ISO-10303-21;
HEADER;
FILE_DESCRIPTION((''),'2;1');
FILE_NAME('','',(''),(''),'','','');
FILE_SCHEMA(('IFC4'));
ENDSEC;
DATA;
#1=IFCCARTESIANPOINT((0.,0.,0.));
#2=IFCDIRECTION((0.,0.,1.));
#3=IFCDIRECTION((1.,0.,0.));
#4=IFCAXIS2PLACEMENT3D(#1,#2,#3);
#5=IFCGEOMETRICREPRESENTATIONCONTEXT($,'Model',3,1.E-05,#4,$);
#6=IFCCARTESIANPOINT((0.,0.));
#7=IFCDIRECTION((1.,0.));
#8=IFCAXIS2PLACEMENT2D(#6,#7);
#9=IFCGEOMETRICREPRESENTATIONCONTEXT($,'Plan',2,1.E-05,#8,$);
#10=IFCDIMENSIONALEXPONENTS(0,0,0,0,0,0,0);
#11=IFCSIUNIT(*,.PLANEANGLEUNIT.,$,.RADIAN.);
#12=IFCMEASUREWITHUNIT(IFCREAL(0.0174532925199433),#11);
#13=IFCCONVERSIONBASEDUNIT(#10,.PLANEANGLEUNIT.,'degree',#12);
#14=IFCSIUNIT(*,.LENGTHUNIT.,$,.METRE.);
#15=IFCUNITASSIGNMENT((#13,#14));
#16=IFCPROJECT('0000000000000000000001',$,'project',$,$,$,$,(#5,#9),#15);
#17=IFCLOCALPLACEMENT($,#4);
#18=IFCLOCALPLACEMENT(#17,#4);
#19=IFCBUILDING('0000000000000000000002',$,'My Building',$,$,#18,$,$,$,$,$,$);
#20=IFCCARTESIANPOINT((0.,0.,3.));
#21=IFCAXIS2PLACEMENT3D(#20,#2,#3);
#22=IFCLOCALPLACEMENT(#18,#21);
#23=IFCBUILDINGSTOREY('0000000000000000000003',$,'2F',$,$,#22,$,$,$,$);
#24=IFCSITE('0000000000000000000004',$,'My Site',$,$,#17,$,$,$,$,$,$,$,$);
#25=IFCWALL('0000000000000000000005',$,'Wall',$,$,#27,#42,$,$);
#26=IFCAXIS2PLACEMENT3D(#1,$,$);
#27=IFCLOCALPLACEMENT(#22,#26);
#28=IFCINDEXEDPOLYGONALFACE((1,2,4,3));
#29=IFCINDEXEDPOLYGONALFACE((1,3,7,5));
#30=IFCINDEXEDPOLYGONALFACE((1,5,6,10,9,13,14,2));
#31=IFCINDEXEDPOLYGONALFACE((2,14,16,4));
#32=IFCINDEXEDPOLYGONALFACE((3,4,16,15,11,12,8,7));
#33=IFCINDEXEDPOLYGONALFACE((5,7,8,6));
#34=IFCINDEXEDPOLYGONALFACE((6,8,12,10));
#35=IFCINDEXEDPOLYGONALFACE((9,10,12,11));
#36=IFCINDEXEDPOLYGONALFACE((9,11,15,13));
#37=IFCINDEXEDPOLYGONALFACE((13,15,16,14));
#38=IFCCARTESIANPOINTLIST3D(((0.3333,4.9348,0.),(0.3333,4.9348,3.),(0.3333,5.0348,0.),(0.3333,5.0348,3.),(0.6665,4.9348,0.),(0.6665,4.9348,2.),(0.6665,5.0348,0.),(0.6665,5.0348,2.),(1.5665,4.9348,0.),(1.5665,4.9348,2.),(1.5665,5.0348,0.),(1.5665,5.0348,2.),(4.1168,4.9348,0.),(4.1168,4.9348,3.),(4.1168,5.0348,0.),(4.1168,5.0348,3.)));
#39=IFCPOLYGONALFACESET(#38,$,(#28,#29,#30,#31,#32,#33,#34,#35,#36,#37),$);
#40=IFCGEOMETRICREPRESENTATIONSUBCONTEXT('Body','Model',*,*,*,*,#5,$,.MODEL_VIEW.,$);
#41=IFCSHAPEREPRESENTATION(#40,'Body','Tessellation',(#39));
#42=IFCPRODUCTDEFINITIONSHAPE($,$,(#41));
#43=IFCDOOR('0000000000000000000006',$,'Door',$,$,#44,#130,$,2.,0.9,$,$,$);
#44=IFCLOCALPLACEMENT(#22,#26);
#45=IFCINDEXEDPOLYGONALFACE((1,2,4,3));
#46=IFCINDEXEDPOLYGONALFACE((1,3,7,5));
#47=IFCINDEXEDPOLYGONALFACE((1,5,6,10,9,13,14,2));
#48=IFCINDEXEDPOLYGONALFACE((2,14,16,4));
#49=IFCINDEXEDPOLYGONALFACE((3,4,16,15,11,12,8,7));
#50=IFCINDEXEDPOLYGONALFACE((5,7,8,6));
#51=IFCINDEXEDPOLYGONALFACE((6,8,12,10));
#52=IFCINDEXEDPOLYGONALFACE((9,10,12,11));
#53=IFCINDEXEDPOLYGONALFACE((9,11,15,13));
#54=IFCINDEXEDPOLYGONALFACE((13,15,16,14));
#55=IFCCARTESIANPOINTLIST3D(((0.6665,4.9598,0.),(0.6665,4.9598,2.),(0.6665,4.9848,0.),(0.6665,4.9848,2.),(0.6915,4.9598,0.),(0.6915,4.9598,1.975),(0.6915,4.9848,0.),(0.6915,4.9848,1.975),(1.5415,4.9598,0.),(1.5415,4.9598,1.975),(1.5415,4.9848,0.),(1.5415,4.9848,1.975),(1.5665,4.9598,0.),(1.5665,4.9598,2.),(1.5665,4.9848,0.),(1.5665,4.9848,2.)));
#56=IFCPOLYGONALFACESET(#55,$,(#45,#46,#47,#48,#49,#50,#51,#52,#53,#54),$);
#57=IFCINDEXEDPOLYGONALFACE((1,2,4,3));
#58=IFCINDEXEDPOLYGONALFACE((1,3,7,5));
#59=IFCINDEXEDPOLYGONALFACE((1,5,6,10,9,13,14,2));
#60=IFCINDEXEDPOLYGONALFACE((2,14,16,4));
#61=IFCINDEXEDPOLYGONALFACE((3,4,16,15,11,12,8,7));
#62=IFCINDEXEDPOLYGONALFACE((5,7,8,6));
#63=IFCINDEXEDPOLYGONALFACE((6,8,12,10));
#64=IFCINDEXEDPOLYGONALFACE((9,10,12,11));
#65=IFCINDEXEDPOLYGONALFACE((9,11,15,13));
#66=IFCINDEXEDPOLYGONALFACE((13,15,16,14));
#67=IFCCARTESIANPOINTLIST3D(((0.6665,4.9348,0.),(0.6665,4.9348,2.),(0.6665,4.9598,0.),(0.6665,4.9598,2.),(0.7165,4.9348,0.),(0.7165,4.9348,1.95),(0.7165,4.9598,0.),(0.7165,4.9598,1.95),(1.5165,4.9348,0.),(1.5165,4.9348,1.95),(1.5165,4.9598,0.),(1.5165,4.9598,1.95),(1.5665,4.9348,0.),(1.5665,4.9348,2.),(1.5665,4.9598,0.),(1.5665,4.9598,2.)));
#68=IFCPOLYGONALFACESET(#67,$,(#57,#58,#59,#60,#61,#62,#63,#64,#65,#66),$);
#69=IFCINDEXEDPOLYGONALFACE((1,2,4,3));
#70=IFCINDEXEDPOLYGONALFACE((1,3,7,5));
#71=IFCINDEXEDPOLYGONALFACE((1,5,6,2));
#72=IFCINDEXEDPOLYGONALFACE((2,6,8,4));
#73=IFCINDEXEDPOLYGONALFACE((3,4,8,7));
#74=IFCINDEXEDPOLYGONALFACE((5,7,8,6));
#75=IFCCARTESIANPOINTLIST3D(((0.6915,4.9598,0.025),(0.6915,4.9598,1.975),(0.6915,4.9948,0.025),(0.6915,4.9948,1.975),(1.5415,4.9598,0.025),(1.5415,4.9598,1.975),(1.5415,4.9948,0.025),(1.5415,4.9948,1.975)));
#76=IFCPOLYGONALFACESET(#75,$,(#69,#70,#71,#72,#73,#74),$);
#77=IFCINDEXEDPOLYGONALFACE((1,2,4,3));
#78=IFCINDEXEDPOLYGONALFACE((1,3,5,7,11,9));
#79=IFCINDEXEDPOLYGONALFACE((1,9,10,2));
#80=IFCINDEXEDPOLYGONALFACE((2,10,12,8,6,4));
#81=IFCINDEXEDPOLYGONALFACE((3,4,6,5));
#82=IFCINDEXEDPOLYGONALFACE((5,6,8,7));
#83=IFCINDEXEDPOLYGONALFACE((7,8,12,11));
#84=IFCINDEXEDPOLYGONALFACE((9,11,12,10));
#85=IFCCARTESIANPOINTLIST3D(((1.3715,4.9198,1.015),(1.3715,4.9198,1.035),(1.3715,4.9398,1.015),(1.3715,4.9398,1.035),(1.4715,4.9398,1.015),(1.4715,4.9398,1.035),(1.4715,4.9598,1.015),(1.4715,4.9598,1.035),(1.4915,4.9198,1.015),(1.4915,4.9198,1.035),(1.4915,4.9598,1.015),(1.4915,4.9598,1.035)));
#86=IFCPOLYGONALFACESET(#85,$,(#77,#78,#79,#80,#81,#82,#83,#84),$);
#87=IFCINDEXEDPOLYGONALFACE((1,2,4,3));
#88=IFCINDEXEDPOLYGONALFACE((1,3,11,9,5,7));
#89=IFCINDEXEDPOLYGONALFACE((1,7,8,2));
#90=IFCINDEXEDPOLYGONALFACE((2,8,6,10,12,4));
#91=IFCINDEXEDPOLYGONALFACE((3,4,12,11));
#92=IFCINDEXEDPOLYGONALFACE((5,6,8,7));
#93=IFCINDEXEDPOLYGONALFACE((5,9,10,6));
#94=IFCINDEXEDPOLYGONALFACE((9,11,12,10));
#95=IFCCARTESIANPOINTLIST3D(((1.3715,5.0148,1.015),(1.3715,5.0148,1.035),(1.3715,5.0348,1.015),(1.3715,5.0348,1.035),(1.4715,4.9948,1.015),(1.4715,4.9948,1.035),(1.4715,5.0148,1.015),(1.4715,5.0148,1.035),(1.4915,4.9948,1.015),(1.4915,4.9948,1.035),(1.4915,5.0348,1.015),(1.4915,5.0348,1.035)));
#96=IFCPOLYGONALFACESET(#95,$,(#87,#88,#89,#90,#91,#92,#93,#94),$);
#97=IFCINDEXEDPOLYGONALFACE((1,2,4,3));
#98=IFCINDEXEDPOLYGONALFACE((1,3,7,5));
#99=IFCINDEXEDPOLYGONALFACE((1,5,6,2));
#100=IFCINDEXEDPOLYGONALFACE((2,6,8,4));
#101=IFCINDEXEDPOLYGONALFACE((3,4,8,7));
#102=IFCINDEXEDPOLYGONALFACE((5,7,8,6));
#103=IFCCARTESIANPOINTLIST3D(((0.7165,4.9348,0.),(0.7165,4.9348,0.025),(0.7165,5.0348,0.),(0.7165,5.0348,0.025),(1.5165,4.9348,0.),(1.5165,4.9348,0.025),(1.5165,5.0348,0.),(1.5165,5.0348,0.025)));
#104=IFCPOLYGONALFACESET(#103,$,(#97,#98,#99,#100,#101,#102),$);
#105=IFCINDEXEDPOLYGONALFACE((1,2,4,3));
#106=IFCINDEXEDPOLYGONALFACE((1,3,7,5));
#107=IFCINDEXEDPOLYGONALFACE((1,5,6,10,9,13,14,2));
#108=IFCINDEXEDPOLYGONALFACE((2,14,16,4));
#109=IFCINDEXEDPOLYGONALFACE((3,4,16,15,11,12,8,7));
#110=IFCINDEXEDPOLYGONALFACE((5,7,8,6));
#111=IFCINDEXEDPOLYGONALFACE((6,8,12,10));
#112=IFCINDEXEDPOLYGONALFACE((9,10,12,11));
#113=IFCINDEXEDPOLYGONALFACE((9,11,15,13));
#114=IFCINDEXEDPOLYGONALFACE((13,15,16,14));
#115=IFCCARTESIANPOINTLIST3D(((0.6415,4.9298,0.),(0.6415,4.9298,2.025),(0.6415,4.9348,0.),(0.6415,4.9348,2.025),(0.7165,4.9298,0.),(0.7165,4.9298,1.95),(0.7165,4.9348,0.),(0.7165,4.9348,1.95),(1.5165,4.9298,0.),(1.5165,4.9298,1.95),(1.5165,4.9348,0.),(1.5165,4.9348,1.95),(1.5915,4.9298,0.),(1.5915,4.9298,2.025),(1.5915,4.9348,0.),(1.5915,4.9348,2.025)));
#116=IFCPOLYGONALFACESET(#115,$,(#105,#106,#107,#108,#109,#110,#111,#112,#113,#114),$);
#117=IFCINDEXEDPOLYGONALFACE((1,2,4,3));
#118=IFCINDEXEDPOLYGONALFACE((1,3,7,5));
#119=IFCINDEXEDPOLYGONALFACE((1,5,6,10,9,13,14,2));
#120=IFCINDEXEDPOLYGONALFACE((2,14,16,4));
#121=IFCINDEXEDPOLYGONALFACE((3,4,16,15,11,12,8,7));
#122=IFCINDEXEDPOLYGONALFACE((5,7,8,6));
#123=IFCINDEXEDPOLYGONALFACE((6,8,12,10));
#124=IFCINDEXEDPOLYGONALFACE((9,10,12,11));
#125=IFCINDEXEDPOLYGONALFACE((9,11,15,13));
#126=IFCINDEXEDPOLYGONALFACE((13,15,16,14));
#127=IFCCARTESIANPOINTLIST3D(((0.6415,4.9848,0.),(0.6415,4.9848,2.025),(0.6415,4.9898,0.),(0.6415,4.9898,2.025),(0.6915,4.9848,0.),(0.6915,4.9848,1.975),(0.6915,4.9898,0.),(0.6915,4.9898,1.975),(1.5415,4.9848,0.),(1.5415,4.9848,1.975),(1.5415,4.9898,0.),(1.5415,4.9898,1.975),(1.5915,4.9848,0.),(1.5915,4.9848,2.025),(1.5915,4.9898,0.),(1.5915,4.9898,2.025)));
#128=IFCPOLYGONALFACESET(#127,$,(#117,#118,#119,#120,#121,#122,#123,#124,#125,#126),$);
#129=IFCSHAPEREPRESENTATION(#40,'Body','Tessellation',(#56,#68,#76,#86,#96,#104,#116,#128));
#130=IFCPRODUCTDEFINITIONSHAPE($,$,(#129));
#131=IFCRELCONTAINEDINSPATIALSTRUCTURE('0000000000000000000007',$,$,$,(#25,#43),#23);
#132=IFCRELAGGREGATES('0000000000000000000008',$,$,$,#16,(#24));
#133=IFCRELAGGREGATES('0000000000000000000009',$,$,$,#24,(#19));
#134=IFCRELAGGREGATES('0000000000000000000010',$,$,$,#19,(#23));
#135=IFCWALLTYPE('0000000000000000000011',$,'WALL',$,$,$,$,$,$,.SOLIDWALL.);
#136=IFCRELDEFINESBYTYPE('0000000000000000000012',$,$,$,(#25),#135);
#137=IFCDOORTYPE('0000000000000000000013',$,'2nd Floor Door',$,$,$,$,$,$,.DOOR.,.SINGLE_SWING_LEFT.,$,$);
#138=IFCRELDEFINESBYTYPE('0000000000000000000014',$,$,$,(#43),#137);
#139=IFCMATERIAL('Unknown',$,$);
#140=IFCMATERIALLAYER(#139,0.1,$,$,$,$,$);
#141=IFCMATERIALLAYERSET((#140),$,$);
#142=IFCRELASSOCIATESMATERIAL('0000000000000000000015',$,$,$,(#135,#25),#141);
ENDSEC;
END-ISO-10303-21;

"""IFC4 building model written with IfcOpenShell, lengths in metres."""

from ifc_helpers import new_model, entity, si_unit, converted_unit, frame, origin_with_axes, origin_2d_with_axis, place, context, subcontext, project, spatial, line, indexed_curve, outline, extrude, shape, source, transform, mapped, material, layer, layer_set, layer_usage, type_object, type_shapes, element, fill, save


model = new_model("IFC4")

# Units and contexts
model_context = context("Model", 3, precision=1e-05, world=origin_with_axes())
plan_context = context("Plan", 2, precision=1e-05, world=origin_2d_with_axis())
body_context_1 = subcontext(model_context, "Body", "Model", "MODEL_VIEW")
body_context_2 = subcontext(plan_context, "Body", "Plan", "PLAN_VIEW")
ifc_project = project(units=[converted_unit("PLANEANGLEUNIT", "degree", entity("IfcReal", 0.0174532925199433), si_unit("PLANEANGLEUNIT", "RADIAN"), dimensions=[0, 0, 0, 0, 0, 0, 0]), si_unit("LENGTHUNIT", "METRE")], contexts=[model_context, plan_context])

# Site, building, storey
site_placement = place(None, origin_with_axes())
site = spatial("IfcSite", under=ifc_project, at=site_placement, Name="My Site")
building_placement = place(site_placement, origin_with_axes())
building = spatial("IfcBuilding", under=site, at=building_placement, Name="My Building")
storey_placement = place(building_placement, frame((0.0, 0.0, 3.0), z_axis=(0.0, 0.0, 1.0), x_axis=(1.0, 0.0, 0.0)))
storey = spatial("IfcBuildingStorey", under=building, at=storey_placement, Name="2F")

# Shared definitions
ifc_material = material(Name="Unknown")

# Shared definitions
ifc_layer_1 = layer(ifc_material, 0.1)
ifc_layer_set_1 = layer_set([ifc_layer_1])
wall_type = type_object("IfcWallType", Name="WALL", PredefinedType="SOLIDWALL", material=ifc_layer_set_1)

# Shared definitions
shared_shape_1 = source(origin_with_axes(), body_context_1, "Body", "SweptSolid", [
    extrude(outline(indexed_curve([(0.0, 0.0), (0.9, 0.0), (0.9, 2.0), (0.0, 2.0)], segments=[line(1, 2, 3, 4, 1)])), frame((0.0, -0.6, 0.0), z_axis=(0.0, -1.0, 0.0), x_axis=(1.0, 0.0, 0.0)), (0.0, 0.0, -1.0), 1.2),
])
door_type = type_object("IfcDoorType", Name="2nd Floor Door", OperationType="SINGLE_SWING_LEFT", PredefinedType="DOOR")
shared_shape_2 = source(origin_with_axes(), body_context_1, "Body", "SweptSolid", [
    extrude(outline(indexed_curve([(0.0, 0.0), (0.0, 2.0), (0.9, 2.0), (0.9, 0.0), (0.875, 0.0), (0.875, 1.975), (0.025, 1.975), (0.025, 0.0)], segments=[line(1, 2, 3, 4, 5, 6, 7, 8, 1)])), frame((0.0, 0.025, 0.0), z_axis=(0.0, -1.0, 0.0), x_axis=(1.0, 0.0, 0.0)), (0.0, 0.0, -1.0), 0.025),
    extrude(outline(indexed_curve([(0.0, 0.0), (0.0, 2.0), (0.9, 2.0), (0.9, 0.0), (0.85, 0.0), (0.85, 1.95), (0.05, 1.95), (0.05, 0.0)], segments=[line(1, 2, 3, 4, 5, 6, 7, 8, 1)])), frame((0.0, 0.0, 0.0), z_axis=(0.0, -1.0, 0.0), x_axis=(1.0, 0.0, 0.0)), (0.0, 0.0, -1.0), 0.025),
    extrude(outline(indexed_curve([(0.0, 0.0), (0.85, 0.0), (0.85, 0.035), (0.0, 0.035)], segments=[line(1, 2, 3, 4, 1)])), frame((0.025, 0.025, 0.025), z_axis=(0.0, 0.0, 1.0), x_axis=(1.0, 0.0, 0.0)), (0.0, 0.0, 1.0), 1.95),
    extrude(outline(indexed_curve([(0.0, 0.0), (0.0, -0.04), (-0.12, -0.04), (-0.12, -0.02), (-0.02, -0.02), (-0.02, 0.0)], segments=[line(1, 2, 3, 4, 5, 6, 1)])), frame((0.825, 0.025, 1.015), z_axis=(0.0, 0.0, 1.0), x_axis=(1.0, 0.0, 0.0)), (0.0, 0.0, 1.0), 0.02),
    extrude(outline(indexed_curve([(0.0, 0.0), (0.0, 0.04), (-0.12, 0.04), (-0.12, 0.02), (-0.02, 0.02), (-0.02, 0.0)], segments=[line(1, 2, 3, 4, 5, 6, 1)])), frame((0.825, 0.06, 1.015), z_axis=(0.0, 0.0, 1.0), x_axis=(1.0, 0.0, 0.0)), (0.0, 0.0, 1.0), 0.02),
    extrude(outline(indexed_curve([(0.0, 0.0), (0.8, 0.0), (0.8, 0.1), (0.0, 0.1)], segments=[line(1, 2, 3, 4, 1)])), frame((0.05, 0.0, 0.0), z_axis=(0.0, 0.0, 1.0), x_axis=(1.0, 0.0, 0.0)), (0.0, 0.0, 1.0), 0.025),
    extrude(outline(indexed_curve([(0.0, 0.0), (0.0, 2.025), (0.95, 2.025), (0.95, 0.0), (0.875, 0.0), (0.875, 1.95), (0.075, 1.95), (0.075, 0.0)], segments=[line(1, 2, 3, 4, 5, 6, 7, 8, 1)])), frame((-0.025, -0.005, 0.0), z_axis=(0.0, -1.0, 0.0), x_axis=(1.0, 0.0, 0.0)), (0.0, 0.0, -1.0), 0.005),
    extrude(outline(indexed_curve([(0.0, 0.0), (0.0, 2.025), (0.95, 2.025), (0.95, 0.0), (0.9, 0.0), (0.9, 1.975), (0.05, 1.975), (0.05, 0.0)], segments=[line(1, 2, 3, 4, 5, 6, 7, 8, 1)])), frame((-0.025, 0.05, 0.0), z_axis=(0.0, -1.0, 0.0), x_axis=(1.0, 0.0, 0.0)), (0.0, 0.0, -1.0), 0.005),
])
shared_shape_3 = source(origin_with_axes(), body_context_2, "Body", "Curve2D", [
    entity("IfcIndexedPolyCurve", entity("IfcCartesianPointList2D", [[0.0, 0.0], [0.0, 0.05], [0.025, 0.05], [0.025, 0.025], [0.05, 0.025], [0.05, 0.0]]), [entity("IfcLineIndex", [1, 2, 3, 4, 5, 6, 1])]),
    entity("IfcIndexedPolyCurve", entity("IfcCartesianPointList2D", [[0.9, 0.0], [0.9, 0.05], [0.875, 0.05], [0.875, 0.025], [0.85, 0.025], [0.85, 0.0]]), [entity("IfcLineIndex", [1, 2, 3, 4, 5, 6, 1])]),
    entity("IfcTrimmedCurve", entity("IfcEllipse", entity("IfcAxis2Placement2D", entity("IfcCartesianPoint", [0.06, 0.05]), entity("IfcDirection", [1.0, 0.0])), 0.815, 0.85), [entity("IfcCartesianPoint", [0.875, 0.05])], [entity("IfcCartesianPoint", [0.06, 0.9])], True, "CARTESIAN"),
    entity("IfcIndexedPolyCurve", entity("IfcCartesianPointList2D", [[0.025, 0.05], [0.06, 0.05], [0.06, 0.9], [0.025, 0.9]]), [entity("IfcLineIndex", [1, 2, 3, 4, 1])]),
])
type_shapes(door_type, [shared_shape_2, shared_shape_3])

# Wall, opening, door
ifc_layer_usage_1 = layer_usage(ifc_layer_set_1, "AXIS2", "POSITIVE", 0.0)
wall_1_placement = place(storey_placement, frame((0.3333, 4.9348, 0.0), z_axis=(0.0, 0.0, 1.0), x_axis=(1.0, 0.0, 0.0)))
wall_1 = element("IfcWall", 1, at=wall_1_placement, inside=storey, type_object=wall_type, material=ifc_layer_usage_1, Name="Wall", context=body_context_1, shape_type="SweptSolid", body=[
    extrude(outline(indexed_curve([(0.0, 0.0), (0.0, 0.1), (3.7834, 0.1), (3.7834, 0.0)], segments=[line(1, 2, 3, 4, 1)])), origin_with_axes(), (0.0, 0.0, 1.0), 3.0),
])
opening_1_placement = place(wall_1_placement, frame((0.3332, 0.0, 0.0), z_axis=(0.0, 0.0, 1.0), x_axis=(1.0, 0.0, 0.0)))
opening_1 = element("IfcOpeningElement", 2, at=opening_1_placement, cuts=wall_1, PredefinedType="OPENING", context=body_context_1, shape_type="MappedRepresentation", body=[
    mapped(shared_shape_1, transform((0.0, 0.0, 0.0), x_axis=(1.0, 0.0, 0.0), y_axis=(0.0, 1.0, 0.0), z_axis=(0.0, 0.0, 1.0), scale=1.0)),
])
door_1_placement = place(opening_1_placement, origin_with_axes())
door_1 = element("IfcDoor", 3, at=door_1_placement, inside=storey, type_object=door_type, Name="Door", OverallHeight=2.0, OverallWidth=0.9, shapes=[
    shape(body_context_1, "Body", "MappedRepresentation", [mapped(shared_shape_2, transform((0.0, 0.0, 0.0), x_axis=(1.0, 0.0, 0.0), y_axis=(0.0, 1.0, 0.0), z_axis=(0.0, 0.0, 1.0), scale=1.0))]),
    shape(body_context_2, "Body", "MappedRepresentation", [mapped(shared_shape_3, transform((0.0, 0.0, 0.0), x_axis=(1.0, 0.0, 0.0), y_axis=(0.0, 1.0, 0.0), z_axis=(0.0, 0.0, 1.0), scale=1.0))]),
])
fill(opening_1, door_1)

save(model, "model.ifc")
